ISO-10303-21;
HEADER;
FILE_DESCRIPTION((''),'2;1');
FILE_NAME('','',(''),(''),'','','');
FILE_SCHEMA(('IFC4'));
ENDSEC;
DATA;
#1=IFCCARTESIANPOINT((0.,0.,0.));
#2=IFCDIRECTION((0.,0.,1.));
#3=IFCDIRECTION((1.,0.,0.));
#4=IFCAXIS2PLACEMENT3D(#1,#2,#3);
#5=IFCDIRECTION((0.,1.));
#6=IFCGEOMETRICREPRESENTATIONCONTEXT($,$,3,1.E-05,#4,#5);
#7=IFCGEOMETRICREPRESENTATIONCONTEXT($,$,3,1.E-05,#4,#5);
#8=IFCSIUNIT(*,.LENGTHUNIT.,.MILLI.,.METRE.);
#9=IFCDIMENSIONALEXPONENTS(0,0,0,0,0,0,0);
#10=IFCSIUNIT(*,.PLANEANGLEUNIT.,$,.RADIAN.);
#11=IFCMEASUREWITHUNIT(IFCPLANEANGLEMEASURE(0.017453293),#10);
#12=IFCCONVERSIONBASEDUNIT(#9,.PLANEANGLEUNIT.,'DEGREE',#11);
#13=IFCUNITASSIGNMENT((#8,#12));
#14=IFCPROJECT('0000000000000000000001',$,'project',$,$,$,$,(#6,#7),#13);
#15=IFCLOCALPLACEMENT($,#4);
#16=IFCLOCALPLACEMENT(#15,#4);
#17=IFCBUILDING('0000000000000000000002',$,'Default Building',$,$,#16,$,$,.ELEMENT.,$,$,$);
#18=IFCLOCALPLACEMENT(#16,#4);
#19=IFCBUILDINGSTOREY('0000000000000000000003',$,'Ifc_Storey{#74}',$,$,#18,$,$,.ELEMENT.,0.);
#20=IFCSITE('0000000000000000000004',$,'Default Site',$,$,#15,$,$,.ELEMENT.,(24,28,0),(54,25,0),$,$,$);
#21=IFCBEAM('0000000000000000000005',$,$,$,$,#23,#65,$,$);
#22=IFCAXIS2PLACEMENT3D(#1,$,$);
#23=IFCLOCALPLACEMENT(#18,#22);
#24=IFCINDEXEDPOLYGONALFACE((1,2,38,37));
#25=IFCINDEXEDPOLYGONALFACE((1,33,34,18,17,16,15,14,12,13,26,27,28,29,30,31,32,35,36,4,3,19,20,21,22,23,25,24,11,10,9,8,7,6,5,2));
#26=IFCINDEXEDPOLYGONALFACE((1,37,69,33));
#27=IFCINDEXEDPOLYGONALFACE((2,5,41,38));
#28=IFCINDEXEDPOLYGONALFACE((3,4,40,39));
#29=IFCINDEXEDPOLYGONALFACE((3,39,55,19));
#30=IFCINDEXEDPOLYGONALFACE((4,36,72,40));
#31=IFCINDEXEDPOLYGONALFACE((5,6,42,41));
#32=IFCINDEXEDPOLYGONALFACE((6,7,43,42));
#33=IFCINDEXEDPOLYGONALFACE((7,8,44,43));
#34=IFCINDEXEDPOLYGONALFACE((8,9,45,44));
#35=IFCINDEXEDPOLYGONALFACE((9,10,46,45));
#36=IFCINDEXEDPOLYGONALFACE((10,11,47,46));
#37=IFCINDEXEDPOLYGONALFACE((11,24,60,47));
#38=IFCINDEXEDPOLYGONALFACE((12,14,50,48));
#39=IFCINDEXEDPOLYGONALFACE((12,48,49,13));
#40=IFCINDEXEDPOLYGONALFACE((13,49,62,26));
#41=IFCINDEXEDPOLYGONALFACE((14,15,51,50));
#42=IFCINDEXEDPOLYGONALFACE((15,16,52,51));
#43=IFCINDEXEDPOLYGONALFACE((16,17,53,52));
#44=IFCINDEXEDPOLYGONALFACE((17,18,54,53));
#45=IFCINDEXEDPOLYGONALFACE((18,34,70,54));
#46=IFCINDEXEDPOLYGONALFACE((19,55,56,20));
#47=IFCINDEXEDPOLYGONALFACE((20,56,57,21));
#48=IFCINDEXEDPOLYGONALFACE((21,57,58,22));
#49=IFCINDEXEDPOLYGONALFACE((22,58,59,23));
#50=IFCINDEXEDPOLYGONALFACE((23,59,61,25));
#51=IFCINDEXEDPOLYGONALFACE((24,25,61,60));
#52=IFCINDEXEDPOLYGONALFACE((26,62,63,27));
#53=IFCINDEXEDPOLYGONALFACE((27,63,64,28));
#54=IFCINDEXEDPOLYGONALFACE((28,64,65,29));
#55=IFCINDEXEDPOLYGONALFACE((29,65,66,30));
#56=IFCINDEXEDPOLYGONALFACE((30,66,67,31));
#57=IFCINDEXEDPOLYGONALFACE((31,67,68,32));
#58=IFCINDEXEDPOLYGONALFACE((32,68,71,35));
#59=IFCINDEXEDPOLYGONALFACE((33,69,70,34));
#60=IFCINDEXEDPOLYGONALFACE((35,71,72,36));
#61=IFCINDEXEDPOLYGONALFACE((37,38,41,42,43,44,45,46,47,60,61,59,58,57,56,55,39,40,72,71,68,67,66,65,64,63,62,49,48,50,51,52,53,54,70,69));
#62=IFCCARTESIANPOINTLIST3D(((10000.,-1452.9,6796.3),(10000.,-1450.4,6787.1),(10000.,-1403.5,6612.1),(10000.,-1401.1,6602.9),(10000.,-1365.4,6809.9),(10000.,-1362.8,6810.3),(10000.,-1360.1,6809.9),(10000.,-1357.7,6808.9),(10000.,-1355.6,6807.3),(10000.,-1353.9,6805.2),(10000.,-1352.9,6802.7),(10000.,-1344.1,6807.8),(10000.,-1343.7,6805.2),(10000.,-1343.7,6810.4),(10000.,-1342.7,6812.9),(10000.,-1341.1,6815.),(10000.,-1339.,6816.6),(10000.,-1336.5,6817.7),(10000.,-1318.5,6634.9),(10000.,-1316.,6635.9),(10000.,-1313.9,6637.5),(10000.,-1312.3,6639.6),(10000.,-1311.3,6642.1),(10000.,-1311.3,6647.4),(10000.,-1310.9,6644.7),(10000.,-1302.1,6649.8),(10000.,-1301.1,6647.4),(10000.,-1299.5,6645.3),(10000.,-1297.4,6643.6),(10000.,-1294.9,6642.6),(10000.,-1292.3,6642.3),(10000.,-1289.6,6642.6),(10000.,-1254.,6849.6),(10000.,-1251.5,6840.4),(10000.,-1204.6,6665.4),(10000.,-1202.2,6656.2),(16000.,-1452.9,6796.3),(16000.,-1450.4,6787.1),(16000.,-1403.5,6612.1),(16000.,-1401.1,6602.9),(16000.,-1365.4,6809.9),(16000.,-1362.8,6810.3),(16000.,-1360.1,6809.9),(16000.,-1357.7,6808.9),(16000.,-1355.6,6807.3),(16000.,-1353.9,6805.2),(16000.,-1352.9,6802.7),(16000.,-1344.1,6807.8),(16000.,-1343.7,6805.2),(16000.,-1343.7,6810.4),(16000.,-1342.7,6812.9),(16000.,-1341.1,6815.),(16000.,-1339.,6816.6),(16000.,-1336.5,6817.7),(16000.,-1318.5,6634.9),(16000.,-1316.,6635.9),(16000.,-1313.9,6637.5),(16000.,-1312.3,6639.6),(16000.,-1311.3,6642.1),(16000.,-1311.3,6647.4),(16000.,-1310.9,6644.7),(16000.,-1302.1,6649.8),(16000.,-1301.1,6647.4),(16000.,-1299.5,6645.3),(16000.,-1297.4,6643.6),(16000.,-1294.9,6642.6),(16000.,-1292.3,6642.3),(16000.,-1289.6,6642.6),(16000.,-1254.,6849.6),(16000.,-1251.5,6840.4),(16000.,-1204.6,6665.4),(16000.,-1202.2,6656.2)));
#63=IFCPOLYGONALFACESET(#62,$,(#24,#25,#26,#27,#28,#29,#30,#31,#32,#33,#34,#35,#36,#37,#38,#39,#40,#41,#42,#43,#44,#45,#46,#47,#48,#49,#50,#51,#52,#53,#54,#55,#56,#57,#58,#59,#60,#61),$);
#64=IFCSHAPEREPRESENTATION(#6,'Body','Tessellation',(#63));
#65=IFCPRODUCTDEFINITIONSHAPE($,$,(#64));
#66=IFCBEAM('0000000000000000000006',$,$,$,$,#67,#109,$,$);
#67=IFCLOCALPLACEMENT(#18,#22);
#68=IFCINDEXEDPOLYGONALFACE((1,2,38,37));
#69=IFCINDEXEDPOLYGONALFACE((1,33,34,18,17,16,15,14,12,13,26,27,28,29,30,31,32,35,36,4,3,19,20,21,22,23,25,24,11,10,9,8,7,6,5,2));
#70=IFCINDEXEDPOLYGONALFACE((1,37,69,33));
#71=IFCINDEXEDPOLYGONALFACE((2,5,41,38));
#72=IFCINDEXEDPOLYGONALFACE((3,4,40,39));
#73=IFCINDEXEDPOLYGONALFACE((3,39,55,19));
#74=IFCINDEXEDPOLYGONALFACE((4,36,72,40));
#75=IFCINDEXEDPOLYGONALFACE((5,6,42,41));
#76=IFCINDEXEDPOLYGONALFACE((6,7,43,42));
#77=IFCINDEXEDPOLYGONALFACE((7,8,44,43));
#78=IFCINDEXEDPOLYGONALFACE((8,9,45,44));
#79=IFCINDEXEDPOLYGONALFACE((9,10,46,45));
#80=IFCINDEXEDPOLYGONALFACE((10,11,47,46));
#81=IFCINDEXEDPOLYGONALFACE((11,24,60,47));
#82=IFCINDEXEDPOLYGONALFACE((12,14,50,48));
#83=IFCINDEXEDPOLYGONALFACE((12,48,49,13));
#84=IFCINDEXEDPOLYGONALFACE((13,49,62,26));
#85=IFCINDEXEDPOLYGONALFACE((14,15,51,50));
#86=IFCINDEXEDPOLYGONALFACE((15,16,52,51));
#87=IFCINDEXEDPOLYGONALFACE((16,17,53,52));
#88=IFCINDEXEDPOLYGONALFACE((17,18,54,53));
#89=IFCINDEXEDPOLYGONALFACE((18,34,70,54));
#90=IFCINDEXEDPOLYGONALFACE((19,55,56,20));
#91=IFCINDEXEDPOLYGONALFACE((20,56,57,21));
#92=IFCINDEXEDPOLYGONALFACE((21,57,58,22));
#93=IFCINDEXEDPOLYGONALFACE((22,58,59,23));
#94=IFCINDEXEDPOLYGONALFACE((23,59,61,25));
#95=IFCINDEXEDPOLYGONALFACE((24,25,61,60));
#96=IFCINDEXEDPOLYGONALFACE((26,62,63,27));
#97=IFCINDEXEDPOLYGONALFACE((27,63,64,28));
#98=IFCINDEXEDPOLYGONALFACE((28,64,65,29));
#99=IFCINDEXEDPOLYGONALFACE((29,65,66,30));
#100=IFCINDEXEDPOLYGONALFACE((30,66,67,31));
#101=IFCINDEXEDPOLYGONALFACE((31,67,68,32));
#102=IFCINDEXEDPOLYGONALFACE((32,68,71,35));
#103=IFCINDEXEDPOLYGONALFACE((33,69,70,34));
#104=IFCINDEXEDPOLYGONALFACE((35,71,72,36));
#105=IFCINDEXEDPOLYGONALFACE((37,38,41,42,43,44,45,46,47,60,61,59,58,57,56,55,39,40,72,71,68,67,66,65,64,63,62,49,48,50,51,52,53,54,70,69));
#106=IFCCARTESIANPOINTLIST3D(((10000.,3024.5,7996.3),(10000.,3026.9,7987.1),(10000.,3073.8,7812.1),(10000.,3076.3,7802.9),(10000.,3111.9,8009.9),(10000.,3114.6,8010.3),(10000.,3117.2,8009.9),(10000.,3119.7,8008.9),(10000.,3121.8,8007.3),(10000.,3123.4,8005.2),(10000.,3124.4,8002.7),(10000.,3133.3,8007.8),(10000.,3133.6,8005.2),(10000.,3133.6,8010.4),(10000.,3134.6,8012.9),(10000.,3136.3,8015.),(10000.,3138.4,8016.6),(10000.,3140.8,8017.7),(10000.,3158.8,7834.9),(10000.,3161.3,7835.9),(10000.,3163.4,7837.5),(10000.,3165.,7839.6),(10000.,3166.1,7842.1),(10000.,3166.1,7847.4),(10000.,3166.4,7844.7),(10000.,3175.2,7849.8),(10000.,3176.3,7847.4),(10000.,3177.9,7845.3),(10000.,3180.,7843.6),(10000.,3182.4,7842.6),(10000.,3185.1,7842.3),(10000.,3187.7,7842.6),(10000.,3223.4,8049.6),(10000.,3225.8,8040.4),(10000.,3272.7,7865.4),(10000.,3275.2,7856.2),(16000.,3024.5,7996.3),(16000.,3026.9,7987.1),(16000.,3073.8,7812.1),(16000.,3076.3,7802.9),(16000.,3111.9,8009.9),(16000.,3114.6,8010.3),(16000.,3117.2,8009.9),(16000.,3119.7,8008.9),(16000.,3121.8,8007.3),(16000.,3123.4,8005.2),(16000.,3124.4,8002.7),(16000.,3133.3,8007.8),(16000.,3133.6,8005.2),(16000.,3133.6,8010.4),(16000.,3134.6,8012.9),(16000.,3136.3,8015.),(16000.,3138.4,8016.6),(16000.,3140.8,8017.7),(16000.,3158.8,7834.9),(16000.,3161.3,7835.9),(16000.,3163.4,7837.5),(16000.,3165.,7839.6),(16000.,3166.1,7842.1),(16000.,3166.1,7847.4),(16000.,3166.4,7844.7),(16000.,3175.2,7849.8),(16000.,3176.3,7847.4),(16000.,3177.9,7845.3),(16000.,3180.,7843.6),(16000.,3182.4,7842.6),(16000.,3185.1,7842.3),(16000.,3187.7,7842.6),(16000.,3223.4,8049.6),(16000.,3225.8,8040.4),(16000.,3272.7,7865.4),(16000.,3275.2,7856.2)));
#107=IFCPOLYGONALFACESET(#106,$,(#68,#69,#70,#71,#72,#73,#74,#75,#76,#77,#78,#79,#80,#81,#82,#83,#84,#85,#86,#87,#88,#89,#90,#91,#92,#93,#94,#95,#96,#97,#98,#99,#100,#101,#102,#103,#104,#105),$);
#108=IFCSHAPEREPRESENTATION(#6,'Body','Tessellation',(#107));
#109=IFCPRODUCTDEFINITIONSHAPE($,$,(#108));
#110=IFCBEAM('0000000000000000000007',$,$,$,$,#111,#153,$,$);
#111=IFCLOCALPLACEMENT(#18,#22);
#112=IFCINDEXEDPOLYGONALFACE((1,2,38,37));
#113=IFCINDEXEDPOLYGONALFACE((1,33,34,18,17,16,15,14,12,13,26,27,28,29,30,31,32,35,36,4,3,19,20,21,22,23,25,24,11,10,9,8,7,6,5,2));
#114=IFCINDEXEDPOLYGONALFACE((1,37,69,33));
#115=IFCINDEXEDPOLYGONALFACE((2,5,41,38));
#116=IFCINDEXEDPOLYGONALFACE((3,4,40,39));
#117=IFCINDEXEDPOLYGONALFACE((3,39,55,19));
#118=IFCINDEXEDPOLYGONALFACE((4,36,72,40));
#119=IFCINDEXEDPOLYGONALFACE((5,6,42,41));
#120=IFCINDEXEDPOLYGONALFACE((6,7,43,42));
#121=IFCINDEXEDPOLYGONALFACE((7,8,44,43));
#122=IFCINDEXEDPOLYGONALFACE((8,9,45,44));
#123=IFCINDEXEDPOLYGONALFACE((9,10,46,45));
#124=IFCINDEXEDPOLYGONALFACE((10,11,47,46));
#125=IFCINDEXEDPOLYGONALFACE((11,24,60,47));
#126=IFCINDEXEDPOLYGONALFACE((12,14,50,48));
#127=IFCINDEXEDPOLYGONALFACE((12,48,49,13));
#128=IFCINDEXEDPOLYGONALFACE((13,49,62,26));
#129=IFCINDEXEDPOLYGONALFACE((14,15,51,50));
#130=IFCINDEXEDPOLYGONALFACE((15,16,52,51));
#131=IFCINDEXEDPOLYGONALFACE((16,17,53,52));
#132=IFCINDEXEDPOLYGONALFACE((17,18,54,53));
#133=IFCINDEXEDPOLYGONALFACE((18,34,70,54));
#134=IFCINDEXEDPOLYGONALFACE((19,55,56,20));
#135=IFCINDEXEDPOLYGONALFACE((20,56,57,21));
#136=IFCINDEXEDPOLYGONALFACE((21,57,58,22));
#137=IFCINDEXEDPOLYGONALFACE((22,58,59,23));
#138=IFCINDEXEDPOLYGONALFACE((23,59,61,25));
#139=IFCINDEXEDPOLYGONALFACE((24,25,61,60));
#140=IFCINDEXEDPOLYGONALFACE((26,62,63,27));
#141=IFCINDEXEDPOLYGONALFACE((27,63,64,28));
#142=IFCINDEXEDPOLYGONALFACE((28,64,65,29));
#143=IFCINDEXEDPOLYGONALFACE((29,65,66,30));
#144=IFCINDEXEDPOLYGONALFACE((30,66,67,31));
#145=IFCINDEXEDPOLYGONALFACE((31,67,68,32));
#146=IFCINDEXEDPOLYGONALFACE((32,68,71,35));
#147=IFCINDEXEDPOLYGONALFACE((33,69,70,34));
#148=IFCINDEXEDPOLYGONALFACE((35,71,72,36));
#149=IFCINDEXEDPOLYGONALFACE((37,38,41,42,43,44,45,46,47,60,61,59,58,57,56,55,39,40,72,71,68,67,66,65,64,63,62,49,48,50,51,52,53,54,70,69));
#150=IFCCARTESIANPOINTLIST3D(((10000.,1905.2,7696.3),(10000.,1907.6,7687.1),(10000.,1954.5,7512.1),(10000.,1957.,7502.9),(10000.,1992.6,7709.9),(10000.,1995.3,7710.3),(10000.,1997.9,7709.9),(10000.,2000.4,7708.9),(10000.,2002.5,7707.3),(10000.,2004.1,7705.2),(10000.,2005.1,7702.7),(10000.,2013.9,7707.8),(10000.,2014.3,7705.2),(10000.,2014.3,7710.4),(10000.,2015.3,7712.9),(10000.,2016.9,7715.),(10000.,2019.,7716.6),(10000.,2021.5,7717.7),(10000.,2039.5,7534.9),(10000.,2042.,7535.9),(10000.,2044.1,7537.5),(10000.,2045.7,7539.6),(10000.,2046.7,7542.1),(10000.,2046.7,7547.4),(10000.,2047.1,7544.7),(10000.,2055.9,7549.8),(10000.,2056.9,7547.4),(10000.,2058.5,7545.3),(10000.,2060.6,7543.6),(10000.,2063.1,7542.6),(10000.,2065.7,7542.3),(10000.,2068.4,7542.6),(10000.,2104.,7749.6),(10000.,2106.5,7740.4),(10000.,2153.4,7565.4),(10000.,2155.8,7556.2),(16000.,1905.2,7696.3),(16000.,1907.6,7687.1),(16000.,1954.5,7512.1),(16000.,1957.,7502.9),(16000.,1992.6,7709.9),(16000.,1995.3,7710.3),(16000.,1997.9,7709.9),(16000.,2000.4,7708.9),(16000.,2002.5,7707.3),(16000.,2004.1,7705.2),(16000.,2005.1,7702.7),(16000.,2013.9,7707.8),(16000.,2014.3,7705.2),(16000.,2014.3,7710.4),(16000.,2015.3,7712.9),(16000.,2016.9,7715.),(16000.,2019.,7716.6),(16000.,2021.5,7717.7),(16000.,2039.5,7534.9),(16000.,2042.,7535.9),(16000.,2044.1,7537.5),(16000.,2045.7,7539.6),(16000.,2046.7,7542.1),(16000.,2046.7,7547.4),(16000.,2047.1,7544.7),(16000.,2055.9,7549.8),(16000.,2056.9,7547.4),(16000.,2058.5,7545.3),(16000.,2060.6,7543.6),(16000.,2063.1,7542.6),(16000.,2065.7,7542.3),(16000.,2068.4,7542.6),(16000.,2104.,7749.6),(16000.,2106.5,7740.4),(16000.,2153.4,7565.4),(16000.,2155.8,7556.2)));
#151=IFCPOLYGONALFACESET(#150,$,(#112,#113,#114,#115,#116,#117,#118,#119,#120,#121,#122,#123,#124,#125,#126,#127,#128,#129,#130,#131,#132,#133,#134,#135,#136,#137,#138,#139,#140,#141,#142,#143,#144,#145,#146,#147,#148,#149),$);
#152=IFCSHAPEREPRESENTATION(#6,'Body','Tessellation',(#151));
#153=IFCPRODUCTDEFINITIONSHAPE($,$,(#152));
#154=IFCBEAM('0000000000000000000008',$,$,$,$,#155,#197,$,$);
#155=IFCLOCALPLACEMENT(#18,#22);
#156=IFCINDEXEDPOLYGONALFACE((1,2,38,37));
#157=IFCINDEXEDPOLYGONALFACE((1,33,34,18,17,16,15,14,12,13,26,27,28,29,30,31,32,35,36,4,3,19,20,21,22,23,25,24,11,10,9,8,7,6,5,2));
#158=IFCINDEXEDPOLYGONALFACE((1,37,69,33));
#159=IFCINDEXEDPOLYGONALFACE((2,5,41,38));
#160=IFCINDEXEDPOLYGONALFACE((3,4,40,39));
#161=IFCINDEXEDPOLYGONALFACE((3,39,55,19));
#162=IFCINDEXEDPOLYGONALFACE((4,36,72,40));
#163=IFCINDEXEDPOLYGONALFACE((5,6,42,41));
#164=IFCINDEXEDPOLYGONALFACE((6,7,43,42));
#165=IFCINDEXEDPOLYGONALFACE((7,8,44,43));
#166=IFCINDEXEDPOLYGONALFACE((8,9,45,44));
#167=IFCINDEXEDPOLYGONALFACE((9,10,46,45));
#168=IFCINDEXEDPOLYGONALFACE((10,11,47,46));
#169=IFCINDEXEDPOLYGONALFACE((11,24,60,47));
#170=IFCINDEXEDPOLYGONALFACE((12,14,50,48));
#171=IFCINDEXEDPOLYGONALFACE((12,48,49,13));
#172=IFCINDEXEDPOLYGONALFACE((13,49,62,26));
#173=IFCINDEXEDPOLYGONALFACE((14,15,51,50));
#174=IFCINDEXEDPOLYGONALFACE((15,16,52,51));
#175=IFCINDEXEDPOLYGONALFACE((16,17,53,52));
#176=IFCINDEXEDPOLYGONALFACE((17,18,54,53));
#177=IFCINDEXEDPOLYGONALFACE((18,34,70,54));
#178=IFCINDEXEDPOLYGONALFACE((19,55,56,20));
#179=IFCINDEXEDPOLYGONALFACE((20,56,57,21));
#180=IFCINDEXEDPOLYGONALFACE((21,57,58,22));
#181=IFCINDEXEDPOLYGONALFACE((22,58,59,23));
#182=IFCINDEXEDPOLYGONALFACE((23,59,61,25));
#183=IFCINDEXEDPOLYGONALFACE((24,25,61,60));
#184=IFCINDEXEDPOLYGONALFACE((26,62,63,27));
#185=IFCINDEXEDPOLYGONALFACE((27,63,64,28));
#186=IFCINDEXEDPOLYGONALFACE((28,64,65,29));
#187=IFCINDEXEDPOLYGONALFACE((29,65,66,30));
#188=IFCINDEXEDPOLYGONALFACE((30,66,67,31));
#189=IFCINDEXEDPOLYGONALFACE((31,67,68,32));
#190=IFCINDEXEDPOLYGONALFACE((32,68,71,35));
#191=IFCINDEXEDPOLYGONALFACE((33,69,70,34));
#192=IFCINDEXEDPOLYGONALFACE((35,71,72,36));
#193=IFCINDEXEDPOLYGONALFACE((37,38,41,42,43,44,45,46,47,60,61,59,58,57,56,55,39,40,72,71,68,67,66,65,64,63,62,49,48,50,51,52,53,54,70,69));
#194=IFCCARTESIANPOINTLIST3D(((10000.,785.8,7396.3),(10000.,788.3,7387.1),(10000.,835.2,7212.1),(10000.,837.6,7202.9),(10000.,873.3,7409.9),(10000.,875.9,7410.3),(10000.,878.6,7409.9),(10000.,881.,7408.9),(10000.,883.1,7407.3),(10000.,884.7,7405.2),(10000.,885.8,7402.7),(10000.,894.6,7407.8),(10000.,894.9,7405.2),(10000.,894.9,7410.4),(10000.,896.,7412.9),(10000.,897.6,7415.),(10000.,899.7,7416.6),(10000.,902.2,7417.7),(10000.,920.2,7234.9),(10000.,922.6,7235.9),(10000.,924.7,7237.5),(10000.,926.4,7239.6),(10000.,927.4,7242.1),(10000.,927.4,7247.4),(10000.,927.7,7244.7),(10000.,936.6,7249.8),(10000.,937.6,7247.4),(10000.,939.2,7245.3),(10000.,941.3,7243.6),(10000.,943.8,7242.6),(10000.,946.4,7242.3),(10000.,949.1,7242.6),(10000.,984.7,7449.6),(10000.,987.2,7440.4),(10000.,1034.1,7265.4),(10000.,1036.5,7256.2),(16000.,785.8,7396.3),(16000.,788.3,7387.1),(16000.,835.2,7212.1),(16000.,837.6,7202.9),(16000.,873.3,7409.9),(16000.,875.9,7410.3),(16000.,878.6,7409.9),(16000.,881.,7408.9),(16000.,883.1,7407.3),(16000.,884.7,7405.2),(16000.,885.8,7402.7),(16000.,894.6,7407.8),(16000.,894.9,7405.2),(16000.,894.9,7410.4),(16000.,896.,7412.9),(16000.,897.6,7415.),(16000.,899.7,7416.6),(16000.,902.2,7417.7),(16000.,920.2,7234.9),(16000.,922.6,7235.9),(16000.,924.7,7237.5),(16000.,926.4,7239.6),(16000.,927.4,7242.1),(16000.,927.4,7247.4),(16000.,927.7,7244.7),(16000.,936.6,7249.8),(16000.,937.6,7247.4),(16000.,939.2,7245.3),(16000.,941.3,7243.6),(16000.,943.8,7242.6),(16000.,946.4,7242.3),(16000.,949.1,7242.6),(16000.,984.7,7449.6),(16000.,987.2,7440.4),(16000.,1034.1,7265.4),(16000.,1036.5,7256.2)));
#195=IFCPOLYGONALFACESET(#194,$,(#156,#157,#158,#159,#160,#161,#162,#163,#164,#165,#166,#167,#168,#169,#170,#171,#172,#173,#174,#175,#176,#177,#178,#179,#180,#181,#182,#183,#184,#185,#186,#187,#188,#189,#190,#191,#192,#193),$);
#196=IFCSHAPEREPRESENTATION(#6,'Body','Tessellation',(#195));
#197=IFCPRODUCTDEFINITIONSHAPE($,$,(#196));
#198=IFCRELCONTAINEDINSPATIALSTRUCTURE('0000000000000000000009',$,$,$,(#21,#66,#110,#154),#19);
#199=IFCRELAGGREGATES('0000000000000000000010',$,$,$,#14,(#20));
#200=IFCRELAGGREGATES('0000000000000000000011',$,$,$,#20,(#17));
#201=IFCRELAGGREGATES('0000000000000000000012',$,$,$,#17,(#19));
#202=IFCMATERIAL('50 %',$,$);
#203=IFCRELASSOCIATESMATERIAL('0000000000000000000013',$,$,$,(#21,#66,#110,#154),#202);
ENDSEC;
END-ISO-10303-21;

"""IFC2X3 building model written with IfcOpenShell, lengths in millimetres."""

from ifc_helpers import new_model, entity, si_unit, converted_unit, direction, frame, origin_with_axes, origin_2d_with_axis, place, context, project, spatial, i_section, extrude, material, element, save


model = new_model("IFC2X3")

# Units and contexts
context_of_model_1 = context(None, 3, precision=1e-05, world=origin_with_axes(), true_north=direction((0.0, 1.0)))
context_of_model_2 = context(None, 3, precision=1e-05, world=origin_with_axes(), true_north=direction((0.0, 1.0)))
ifc_project = project(units=[si_unit("LENGTHUNIT", "METRE", prefix="MILLI"), converted_unit("PLANEANGLEUNIT", "DEGREE", entity("IfcPlaneAngleMeasure", 0.017453293), si_unit("PLANEANGLEUNIT", "RADIAN"), dimensions=[0, 0, 0, 0, 0, 0, 0])], contexts=[context_of_model_1, context_of_model_2])

# Site, building, storey
site_placement = place(None, origin_with_axes())
site = spatial("IfcSite", under=ifc_project, at=site_placement, Name="Default Site", CompositionType="ELEMENT", RefLatitude=(24, 28, 0), RefLongitude=(54, 25, 0))
building_placement = place(site_placement, origin_with_axes())
building = spatial("IfcBuilding", under=site, at=building_placement, Name="Default Building", CompositionType="ELEMENT")
storey_placement = place(building_placement, origin_with_axes())
storey = spatial("IfcBuildingStorey", under=building, at=storey_placement, Name="Ifc_Storey{#74}", CompositionType="ELEMENT", Elevation=0.0)

# Shared definitions
ifc_material_1 = material(Name="50 %")

# Beams
for number, where, z_axis, x_axis in (
    (1, (10000.0, -1327.5, 6726.3), (0.0, -0.258819, 0.965926), (-1.0, 0.0, 0.0)),
    (2, (10000.0, 3149.8, 7926.3), (0.0, -0.258819, 0.965926), (-1.0, 0.0, 0.0)),
    (3, (10000.0, 2030.5, 7626.3), (0.0, -0.258819, 0.965926), (-1.0, 0.0, 0.0)),
    (4, (10000.0, 911.2, 7326.3), (0.0, -0.258819, 0.965926), (-1.0, 0.0, 0.0)),
):
    element("IfcBeam", number, at=place(storey_placement, frame(where, z_axis=z_axis, x_axis=x_axis)), inside=storey, material=ifc_material_1, context=context_of_model_1, shape_type="SweptSolid", body=[
        extrude(i_section(OverallWidth=205.9, OverallDepth=200.2, WebThickness=9.5, FlangeThickness=9.5, FilletRadius=10.2, at=origin_2d_with_axis()), frame((0.0, 0.0, 0.0), z_axis=(-1.0, 0.0, 0.0), x_axis=(0.0, 1.0, 0.0)), (0.0, 0.0, 1.0), 6000.0),
    ])

save(model, "model.ifc")
